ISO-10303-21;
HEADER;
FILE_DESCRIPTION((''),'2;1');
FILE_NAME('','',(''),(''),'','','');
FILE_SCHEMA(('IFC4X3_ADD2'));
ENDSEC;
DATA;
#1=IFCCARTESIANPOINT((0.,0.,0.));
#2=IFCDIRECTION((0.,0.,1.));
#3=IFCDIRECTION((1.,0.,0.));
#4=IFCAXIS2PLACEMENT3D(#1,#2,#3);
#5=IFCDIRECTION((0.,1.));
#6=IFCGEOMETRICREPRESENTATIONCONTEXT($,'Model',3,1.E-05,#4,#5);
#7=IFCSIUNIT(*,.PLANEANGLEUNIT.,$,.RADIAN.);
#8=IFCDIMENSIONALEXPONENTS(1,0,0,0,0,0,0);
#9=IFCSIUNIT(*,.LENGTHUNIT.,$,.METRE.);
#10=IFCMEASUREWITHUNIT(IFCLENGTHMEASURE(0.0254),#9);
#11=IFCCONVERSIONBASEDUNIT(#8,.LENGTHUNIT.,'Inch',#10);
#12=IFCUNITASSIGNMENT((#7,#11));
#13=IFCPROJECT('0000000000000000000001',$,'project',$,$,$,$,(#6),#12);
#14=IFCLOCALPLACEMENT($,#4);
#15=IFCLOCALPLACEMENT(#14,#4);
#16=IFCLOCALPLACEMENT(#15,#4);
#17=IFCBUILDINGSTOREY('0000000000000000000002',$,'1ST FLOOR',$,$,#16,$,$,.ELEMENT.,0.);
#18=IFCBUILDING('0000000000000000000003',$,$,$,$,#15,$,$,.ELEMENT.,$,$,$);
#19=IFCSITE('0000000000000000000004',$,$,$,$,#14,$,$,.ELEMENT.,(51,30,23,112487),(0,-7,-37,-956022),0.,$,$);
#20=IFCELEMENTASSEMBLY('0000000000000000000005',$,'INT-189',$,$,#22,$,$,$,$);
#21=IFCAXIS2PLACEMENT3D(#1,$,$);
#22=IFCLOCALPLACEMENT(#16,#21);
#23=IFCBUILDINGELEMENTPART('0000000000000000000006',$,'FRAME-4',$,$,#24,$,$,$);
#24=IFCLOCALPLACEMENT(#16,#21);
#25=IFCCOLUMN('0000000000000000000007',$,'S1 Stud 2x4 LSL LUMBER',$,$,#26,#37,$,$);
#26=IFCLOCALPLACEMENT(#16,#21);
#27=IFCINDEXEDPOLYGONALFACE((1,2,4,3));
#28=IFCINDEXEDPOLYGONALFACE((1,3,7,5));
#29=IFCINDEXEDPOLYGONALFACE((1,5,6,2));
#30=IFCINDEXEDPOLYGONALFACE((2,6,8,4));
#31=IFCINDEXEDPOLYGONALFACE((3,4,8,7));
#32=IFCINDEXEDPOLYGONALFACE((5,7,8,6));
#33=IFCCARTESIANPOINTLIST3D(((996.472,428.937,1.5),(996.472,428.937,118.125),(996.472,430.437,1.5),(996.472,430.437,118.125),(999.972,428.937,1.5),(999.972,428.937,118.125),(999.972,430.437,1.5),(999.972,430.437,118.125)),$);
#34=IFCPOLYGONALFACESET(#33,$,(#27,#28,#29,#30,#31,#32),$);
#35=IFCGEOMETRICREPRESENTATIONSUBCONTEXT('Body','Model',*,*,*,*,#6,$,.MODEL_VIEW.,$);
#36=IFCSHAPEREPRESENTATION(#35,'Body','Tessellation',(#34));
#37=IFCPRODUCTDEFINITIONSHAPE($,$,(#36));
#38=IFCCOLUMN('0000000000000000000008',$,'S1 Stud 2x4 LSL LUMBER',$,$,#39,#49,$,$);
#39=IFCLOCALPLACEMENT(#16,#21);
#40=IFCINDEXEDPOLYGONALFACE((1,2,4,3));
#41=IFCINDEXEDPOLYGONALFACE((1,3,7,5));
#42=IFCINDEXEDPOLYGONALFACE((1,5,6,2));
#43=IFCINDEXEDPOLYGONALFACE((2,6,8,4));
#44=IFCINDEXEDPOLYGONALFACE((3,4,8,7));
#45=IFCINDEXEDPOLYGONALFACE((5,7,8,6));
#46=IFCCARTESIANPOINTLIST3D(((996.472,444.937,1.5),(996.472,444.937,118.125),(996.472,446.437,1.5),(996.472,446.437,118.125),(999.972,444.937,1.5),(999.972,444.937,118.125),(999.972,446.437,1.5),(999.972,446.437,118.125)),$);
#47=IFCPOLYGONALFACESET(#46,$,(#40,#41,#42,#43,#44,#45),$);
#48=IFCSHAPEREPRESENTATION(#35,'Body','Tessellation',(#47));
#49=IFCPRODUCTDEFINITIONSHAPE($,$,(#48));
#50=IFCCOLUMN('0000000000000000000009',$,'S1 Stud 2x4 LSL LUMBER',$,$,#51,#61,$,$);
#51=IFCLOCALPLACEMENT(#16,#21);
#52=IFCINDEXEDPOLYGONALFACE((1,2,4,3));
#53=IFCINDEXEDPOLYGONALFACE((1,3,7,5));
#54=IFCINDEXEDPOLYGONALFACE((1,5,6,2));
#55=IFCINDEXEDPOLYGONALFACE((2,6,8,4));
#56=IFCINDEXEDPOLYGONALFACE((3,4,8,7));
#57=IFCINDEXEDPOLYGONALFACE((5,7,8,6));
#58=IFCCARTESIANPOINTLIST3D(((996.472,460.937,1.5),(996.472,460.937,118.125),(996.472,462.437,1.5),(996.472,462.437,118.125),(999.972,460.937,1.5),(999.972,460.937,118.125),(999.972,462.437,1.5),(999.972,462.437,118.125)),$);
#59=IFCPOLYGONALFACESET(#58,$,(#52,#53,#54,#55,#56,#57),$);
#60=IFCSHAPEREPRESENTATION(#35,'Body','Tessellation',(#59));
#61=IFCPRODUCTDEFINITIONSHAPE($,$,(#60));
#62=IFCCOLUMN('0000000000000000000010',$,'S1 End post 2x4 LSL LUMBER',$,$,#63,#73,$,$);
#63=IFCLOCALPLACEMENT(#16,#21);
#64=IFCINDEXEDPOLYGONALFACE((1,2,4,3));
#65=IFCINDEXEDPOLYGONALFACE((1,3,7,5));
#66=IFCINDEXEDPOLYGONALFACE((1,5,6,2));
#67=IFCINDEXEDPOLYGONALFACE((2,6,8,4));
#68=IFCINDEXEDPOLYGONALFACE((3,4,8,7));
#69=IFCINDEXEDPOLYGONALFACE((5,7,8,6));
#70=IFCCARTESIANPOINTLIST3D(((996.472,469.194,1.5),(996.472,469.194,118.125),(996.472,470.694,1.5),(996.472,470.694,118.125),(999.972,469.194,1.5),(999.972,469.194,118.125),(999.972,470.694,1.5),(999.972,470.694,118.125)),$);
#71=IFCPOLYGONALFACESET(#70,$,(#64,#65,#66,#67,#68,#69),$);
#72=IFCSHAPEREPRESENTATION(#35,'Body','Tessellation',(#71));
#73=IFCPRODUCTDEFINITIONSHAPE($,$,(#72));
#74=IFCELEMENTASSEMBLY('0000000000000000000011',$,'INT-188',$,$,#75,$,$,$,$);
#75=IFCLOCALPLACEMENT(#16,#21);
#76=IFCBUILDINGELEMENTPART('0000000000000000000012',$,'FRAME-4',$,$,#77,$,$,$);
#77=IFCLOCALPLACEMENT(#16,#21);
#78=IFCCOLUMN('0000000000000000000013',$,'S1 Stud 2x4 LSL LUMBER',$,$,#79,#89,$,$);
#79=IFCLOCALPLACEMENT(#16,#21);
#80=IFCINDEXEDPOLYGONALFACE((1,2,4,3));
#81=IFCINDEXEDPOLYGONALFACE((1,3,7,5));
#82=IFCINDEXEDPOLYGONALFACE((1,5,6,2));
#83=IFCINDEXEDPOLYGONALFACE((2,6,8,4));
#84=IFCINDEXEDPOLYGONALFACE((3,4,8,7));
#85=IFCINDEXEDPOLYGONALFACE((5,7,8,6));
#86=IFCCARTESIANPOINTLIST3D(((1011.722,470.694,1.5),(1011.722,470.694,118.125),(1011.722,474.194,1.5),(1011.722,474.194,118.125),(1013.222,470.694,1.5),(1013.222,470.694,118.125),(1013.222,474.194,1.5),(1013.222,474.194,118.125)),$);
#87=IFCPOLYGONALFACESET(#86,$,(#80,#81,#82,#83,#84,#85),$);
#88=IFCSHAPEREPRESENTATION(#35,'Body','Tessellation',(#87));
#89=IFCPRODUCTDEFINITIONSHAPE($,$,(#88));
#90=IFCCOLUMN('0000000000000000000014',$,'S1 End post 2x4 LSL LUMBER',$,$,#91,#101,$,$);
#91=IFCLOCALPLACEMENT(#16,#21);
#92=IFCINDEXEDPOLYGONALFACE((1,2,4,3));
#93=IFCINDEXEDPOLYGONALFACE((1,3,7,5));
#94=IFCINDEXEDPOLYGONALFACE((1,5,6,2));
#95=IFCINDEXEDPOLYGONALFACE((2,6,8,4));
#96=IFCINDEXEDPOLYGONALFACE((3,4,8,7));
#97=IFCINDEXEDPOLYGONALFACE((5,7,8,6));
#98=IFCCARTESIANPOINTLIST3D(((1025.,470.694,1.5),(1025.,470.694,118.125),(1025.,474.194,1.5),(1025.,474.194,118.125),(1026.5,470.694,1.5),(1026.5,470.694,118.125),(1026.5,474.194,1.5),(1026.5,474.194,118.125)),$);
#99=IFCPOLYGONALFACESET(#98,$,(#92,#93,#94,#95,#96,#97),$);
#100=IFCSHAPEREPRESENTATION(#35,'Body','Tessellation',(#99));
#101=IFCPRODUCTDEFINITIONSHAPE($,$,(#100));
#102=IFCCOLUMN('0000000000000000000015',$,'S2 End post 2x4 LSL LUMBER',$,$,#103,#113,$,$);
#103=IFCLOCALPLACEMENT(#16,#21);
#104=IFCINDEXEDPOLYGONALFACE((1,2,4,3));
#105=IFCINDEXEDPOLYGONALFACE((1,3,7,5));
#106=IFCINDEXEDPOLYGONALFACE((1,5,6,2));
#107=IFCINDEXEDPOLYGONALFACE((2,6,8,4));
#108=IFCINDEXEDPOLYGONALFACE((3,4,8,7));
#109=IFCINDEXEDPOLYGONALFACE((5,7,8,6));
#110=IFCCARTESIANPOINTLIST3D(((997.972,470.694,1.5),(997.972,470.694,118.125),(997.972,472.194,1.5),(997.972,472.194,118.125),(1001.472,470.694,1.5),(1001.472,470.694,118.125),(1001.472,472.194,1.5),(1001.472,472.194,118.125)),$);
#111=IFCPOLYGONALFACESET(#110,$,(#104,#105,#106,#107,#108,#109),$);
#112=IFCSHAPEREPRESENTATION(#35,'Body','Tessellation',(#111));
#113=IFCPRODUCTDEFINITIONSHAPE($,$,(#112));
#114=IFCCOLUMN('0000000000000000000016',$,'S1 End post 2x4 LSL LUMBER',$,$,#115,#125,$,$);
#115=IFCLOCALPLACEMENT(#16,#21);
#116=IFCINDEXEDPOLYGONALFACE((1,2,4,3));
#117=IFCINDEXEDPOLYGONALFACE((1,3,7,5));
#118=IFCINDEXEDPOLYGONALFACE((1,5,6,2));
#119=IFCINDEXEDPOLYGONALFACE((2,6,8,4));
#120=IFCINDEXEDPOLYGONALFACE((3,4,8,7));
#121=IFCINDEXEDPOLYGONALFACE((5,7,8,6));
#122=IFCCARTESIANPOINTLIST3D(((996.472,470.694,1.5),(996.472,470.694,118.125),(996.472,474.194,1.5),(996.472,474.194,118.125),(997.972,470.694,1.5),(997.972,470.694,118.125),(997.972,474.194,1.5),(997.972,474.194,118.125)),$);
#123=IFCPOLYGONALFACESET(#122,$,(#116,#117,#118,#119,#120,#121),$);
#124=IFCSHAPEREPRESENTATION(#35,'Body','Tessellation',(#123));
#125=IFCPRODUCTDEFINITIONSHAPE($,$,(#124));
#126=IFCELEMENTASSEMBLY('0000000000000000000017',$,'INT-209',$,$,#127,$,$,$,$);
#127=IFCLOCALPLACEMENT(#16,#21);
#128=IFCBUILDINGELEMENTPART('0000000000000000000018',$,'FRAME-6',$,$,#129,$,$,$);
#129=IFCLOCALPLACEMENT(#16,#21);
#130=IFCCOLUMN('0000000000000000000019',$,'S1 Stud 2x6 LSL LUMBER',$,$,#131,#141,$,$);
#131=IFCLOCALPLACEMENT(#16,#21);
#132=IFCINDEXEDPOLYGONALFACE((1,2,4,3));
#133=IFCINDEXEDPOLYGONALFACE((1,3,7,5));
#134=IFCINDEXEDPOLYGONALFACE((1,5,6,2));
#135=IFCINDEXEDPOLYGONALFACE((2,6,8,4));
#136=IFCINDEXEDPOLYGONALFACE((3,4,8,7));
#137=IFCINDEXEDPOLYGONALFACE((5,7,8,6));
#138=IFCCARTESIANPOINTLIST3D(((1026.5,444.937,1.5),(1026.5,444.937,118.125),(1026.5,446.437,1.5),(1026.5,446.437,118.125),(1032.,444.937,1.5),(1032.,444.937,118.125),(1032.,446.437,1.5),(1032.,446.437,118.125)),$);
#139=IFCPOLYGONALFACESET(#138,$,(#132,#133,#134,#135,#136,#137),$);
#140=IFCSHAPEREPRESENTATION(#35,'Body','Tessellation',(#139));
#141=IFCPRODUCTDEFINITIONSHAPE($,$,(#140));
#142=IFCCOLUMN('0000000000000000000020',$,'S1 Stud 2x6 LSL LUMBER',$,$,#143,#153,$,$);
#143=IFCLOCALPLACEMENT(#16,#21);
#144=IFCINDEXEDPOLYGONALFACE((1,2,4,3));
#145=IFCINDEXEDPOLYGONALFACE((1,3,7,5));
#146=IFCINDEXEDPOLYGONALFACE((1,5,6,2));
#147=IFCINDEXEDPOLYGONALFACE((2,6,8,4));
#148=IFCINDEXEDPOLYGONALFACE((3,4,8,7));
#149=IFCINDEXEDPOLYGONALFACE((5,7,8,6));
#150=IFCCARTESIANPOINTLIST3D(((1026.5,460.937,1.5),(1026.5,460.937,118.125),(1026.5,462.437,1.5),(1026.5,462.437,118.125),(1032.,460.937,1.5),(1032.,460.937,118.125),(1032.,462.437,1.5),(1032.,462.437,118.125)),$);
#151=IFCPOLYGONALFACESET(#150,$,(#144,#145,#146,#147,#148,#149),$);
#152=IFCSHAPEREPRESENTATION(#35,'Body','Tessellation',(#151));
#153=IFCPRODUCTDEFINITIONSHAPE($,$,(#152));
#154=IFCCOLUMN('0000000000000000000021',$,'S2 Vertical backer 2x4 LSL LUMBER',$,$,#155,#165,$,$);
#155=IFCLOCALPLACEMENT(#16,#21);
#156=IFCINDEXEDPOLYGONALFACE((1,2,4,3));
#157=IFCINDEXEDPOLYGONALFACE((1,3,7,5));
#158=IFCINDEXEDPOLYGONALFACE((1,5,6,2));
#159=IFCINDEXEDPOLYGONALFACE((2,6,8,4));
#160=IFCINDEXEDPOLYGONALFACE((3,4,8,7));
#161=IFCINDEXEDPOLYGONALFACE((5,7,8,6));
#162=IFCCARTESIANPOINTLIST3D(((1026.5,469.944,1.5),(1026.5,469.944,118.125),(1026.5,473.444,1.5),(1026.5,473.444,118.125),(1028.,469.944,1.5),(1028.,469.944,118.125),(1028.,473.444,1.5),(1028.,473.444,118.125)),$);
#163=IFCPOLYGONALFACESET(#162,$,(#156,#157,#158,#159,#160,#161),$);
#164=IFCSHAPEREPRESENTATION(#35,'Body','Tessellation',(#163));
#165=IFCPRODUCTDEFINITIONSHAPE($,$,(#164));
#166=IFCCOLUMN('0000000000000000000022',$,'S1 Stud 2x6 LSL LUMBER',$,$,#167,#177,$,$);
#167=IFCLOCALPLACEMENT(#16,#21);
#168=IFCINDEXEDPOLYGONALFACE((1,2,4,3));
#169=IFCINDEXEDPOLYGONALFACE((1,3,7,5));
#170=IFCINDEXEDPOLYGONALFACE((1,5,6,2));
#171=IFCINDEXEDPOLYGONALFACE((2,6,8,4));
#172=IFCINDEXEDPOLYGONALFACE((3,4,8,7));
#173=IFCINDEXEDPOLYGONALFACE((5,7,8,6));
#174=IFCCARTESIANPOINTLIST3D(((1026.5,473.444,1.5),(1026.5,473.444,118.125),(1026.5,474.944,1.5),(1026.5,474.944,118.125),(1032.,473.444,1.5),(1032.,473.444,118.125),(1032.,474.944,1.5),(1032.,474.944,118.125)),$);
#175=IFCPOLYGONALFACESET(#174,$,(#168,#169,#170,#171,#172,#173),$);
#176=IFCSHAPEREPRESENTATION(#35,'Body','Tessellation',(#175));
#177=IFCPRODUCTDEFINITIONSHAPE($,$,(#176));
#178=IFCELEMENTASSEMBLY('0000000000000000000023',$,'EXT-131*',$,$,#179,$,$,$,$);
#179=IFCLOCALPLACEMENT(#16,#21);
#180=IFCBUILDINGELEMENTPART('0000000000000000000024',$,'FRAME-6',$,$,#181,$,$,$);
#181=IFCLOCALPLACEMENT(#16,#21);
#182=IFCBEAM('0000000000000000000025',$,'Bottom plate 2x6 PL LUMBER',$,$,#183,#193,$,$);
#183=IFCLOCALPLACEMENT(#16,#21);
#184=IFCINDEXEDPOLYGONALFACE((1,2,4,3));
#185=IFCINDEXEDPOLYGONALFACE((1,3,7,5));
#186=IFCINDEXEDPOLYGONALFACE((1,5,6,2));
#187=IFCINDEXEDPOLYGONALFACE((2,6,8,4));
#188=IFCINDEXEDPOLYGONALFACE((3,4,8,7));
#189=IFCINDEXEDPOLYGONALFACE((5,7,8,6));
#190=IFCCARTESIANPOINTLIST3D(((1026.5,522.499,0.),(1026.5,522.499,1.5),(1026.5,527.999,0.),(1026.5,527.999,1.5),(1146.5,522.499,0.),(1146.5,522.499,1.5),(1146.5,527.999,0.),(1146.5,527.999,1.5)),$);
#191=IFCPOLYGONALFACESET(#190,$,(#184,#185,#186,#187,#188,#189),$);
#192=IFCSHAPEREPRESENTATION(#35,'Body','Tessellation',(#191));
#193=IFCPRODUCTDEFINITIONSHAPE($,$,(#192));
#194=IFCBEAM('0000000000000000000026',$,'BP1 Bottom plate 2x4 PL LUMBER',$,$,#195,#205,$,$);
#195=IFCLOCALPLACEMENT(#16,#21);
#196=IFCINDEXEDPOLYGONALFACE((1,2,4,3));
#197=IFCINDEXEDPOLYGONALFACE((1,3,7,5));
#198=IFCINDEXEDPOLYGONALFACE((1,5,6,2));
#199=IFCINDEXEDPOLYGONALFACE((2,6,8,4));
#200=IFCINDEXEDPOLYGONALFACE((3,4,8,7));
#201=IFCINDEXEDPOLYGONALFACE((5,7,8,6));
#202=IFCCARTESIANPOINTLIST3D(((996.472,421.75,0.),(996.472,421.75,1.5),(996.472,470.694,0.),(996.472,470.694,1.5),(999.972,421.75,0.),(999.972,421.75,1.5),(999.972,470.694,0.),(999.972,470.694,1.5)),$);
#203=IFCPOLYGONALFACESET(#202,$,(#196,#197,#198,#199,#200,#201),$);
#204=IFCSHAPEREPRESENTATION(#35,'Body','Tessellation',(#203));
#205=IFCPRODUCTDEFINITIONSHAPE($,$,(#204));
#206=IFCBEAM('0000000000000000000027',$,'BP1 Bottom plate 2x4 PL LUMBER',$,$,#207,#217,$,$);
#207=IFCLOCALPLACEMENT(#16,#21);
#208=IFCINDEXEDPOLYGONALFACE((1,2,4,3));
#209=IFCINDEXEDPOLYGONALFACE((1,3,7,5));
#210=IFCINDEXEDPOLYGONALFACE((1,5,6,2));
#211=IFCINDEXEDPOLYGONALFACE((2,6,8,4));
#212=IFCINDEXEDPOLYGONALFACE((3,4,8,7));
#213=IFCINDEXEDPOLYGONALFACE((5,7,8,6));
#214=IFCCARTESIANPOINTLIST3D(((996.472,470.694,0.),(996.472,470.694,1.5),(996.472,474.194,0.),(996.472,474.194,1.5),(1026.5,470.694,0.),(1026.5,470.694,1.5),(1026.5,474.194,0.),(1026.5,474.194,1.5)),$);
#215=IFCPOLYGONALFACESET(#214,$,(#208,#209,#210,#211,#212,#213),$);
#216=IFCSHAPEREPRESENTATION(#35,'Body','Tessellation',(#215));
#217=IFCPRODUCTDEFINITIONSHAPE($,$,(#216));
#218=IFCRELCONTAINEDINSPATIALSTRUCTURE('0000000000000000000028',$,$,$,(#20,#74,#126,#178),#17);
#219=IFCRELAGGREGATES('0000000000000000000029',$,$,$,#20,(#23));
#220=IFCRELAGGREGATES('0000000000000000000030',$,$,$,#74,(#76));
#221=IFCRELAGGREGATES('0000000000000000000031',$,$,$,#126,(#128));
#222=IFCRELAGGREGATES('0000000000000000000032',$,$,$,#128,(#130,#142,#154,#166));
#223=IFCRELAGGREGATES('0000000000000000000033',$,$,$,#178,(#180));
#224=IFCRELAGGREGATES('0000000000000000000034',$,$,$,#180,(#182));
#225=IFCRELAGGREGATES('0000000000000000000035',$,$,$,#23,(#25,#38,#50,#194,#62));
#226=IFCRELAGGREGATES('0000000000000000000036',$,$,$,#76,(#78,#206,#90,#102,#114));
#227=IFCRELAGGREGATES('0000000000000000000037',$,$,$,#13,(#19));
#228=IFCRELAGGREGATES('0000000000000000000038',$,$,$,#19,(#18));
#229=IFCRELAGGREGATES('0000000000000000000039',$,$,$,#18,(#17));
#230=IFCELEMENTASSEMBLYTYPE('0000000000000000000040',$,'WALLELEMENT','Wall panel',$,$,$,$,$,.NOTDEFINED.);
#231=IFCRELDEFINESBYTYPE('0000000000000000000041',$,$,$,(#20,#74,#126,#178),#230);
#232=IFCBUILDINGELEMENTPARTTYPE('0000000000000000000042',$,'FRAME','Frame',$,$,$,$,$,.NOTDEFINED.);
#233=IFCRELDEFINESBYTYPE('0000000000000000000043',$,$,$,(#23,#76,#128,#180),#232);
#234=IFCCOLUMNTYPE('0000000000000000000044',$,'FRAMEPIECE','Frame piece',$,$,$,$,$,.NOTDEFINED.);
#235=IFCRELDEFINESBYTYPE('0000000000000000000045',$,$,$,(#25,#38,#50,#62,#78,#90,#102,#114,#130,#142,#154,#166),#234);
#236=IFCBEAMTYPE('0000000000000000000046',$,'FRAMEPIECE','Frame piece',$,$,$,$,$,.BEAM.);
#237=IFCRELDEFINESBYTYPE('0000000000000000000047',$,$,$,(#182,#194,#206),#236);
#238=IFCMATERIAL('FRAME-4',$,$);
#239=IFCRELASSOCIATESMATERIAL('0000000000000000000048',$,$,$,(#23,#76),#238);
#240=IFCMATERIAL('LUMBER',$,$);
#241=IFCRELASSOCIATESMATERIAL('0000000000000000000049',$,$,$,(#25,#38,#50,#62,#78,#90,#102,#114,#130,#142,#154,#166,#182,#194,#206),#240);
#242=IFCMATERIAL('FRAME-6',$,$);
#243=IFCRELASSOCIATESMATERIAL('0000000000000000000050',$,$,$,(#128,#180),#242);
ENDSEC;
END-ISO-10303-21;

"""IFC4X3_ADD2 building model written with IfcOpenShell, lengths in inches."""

from ifc_helpers import new_model, entity, si_unit, converted_unit, direction, frame, origin_with_axes, origin_2d_with_axis, place, context, subcontext, project, spatial, rectangle, extrude, material, type_object, element, aggregate, save


model = new_model("IFC4X3_ADD2")

# Units and contexts
model_context = context("Model", 3, precision=1e-05, world=origin_with_axes(), true_north=direction((0.0, 1.0)))
body_context = subcontext(model_context, "Body", "Model", "MODEL_VIEW")
ifc_project = project(units=[si_unit("PLANEANGLEUNIT", "RADIAN"), converted_unit("LENGTHUNIT", "Inch", entity("IfcLengthMeasure", 0.0254), si_unit("LENGTHUNIT", "METRE"), dimensions=[1, 0, 0, 0, 0, 0, 0])], contexts=[model_context])

# Site, building, storey
site_placement = place(None, origin_with_axes())
site = spatial("IfcSite", under=ifc_project, at=site_placement, CompositionType="ELEMENT", RefLatitude=(51, 30, 23, 112487), RefLongitude=(0, -7, -37, -956022), RefElevation=0.0)
building_placement = place(site_placement, origin_with_axes())
building = spatial("IfcBuilding", under=site, at=building_placement, CompositionType="ELEMENT")
storey_placement = place(building_placement, origin_with_axes())
storey = spatial("IfcBuildingStorey", under=building, at=storey_placement, Name="1ST FLOOR", CompositionType="ELEMENT", Elevation=0.0)

# Element assemblies, building element parts, columns
element_assembly_type_1 = type_object("IfcElementAssemblyType", Name="WALLELEMENT", Description="Wall panel", PredefinedType="NOTDEFINED")
assembly_1_placement = place(storey_placement, origin_with_axes())
assembly_1 = element("IfcElementAssembly", 1, at=assembly_1_placement, inside=storey, type_object=element_assembly_type_1, Name="INT-189")
ifc_material_1 = material(Name="FRAME-4")
building_element_part_type = type_object("IfcBuildingElementPartType", Name="FRAME", Description="Frame", PredefinedType="NOTDEFINED")
building_element_part_1_placement = place(storey_placement, origin_with_axes())
building_element_part_1 = element("IfcBuildingElementPart", 2, at=building_element_part_1_placement, type_object=building_element_part_type, material=ifc_material_1, Name="FRAME-4")
aggregate(assembly_1, [building_element_part_1])
ifc_material_2 = material(Name="LUMBER")
column_type = type_object("IfcColumnType", Name="FRAMEPIECE", Description="Frame piece", PredefinedType="NOTDEFINED")
column_1_placement = place(storey_placement, frame((998.222, 429.687, 118.125), z_axis=(0.0, 0.0, -1.0), x_axis=(0.0, -1.0, 0.0)))
column_1 = element("IfcColumn", 3, at=column_1_placement, type_object=column_type, material=ifc_material_2, Name="S1 Stud 2x4 LSL LUMBER", context=body_context, shape_type="SweptSolid", body=[
    extrude(rectangle(XDim=1.5, YDim=3.5, at=origin_2d_with_axis()), origin_with_axes(), (0.0, 0.0, 1.0), 116.625),
])
column_2_placement = place(storey_placement, frame((998.222, 445.687, 118.125), z_axis=(0.0, 0.0, -1.0), x_axis=(0.0, -1.0, 0.0)))
column_2 = element("IfcColumn", 4, at=column_2_placement, type_object=column_type, material=ifc_material_2, Name="S1 Stud 2x4 LSL LUMBER", context=body_context, shape_type="SweptSolid", body=[
    extrude(rectangle(XDim=1.5, YDim=3.5, at=origin_2d_with_axis()), origin_with_axes(), (0.0, 0.0, 1.0), 116.625),
])
column_3_placement = place(storey_placement, frame((998.222, 461.687, 118.125), z_axis=(0.0, 0.0, -1.0), x_axis=(0.0, -1.0, 0.0)))
column_3 = element("IfcColumn", 5, at=column_3_placement, type_object=column_type, material=ifc_material_2, Name="S1 Stud 2x4 LSL LUMBER", context=body_context, shape_type="SweptSolid", body=[
    extrude(rectangle(XDim=1.5, YDim=3.5, at=origin_2d_with_axis()), origin_with_axes(), (0.0, 0.0, 1.0), 116.625),
])
column_4_placement = place(storey_placement, frame((998.222, 469.944, 118.125), z_axis=(0.0, 0.0, -1.0), x_axis=(0.0, -1.0, 0.0)))
column_4 = element("IfcColumn", 6, at=column_4_placement, type_object=column_type, material=ifc_material_2, Name="S1 End post 2x4 LSL LUMBER", context=body_context, shape_type="SweptSolid", body=[
    extrude(rectangle(XDim=1.5, YDim=3.5, at=origin_2d_with_axis()), origin_with_axes(), (0.0, 0.0, 1.0), 116.625),
])
assembly_2_placement = place(storey_placement, origin_with_axes())
assembly_2 = element("IfcElementAssembly", 7, at=assembly_2_placement, inside=storey, type_object=element_assembly_type_1, Name="INT-188")
building_element_part_2_placement = place(storey_placement, origin_with_axes())
building_element_part_2 = element("IfcBuildingElementPart", 8, at=building_element_part_2_placement, type_object=building_element_part_type, material=ifc_material_1, Name="FRAME-4")
aggregate(assembly_2, [building_element_part_2])
column_5_placement = place(storey_placement, frame((1012.472, 472.444, 118.125), z_axis=(0.0, 0.0, -1.0), x_axis=(1.0, 0.0, 0.0)))
column_5 = element("IfcColumn", 9, at=column_5_placement, type_object=column_type, material=ifc_material_2, Name="S1 Stud 2x4 LSL LUMBER", context=body_context, shape_type="SweptSolid", body=[
    extrude(rectangle(XDim=1.5, YDim=3.5, at=origin_2d_with_axis()), origin_with_axes(), (0.0, 0.0, 1.0), 116.625),
])
column_6_placement = place(storey_placement, frame((1025.75, 472.444, 1.5), z_axis=(0.0, 0.0, 1.0), x_axis=(-1.0, 0.0, 0.0)))
column_6 = element("IfcColumn", 10, at=column_6_placement, type_object=column_type, material=ifc_material_2, Name="S1 End post 2x4 LSL LUMBER", context=body_context, shape_type="SweptSolid", body=[
    extrude(rectangle(XDim=1.5, YDim=3.5, at=origin_2d_with_axis()), origin_with_axes(), (0.0, 0.0, 1.0), 116.625),
])
column_7_placement = place(storey_placement, frame((999.722, 471.444, 118.125), z_axis=(0.0, 0.0, -1.0), x_axis=(0.0, 1.0, 0.0)))
column_7 = element("IfcColumn", 11, at=column_7_placement, type_object=column_type, material=ifc_material_2, Name="S2 End post 2x4 LSL LUMBER", context=body_context, shape_type="SweptSolid", body=[
    extrude(rectangle(XDim=1.5, YDim=3.5, at=origin_2d_with_axis()), origin_with_axes(), (0.0, 0.0, 1.0), 116.625),
])
column_8_placement = place(storey_placement, frame((997.222, 472.444, 118.125), z_axis=(0.0, 0.0, -1.0), x_axis=(1.0, 0.0, 0.0)))
column_8 = element("IfcColumn", 12, at=column_8_placement, type_object=column_type, material=ifc_material_2, Name="S1 End post 2x4 LSL LUMBER", context=body_context, shape_type="SweptSolid", body=[
    extrude(rectangle(XDim=1.5, YDim=3.5, at=origin_2d_with_axis()), origin_with_axes(), (0.0, 0.0, 1.0), 116.625),
])
assembly_3_placement = place(storey_placement, origin_with_axes())
assembly_3 = element("IfcElementAssembly", 13, at=assembly_3_placement, inside=storey, type_object=element_assembly_type_1, Name="INT-209")
ifc_material_3 = material(Name="FRAME-6")
building_element_part_3_placement = place(storey_placement, origin_with_axes())
building_element_part_3 = element("IfcBuildingElementPart", 14, at=building_element_part_3_placement, type_object=building_element_part_type, material=ifc_material_3, Name="FRAME-6")
aggregate(assembly_3, [building_element_part_3])
column_9_placement = place(storey_placement, frame((1029.25, 445.687, 118.125), z_axis=(0.0, 0.0, -1.0), x_axis=(0.0, -1.0, 0.0)))
column_9 = element("IfcColumn", 15, at=column_9_placement, type_object=column_type, material=ifc_material_2, Name="S1 Stud 2x6 LSL LUMBER", context=body_context, shape_type="SweptSolid", body=[
    extrude(rectangle(XDim=1.5, YDim=5.5, at=origin_2d_with_axis()), origin_with_axes(), (0.0, 0.0, 1.0), 116.625),
])
column_10_placement = place(storey_placement, frame((1029.25, 461.687, 118.125), z_axis=(0.0, 0.0, -1.0), x_axis=(0.0, -1.0, 0.0)))
column_10 = element("IfcColumn", 16, at=column_10_placement, type_object=column_type, material=ifc_material_2, Name="S1 Stud 2x6 LSL LUMBER", context=body_context, shape_type="SweptSolid", body=[
    extrude(rectangle(XDim=1.5, YDim=5.5, at=origin_2d_with_axis()), origin_with_axes(), (0.0, 0.0, 1.0), 116.625),
])
column_11_placement = place(storey_placement, frame((1027.25, 471.694, 1.5), z_axis=(0.0, 0.0, 1.0), x_axis=(1.0, 0.0, 0.0)))
column_11 = element("IfcColumn", 17, at=column_11_placement, type_object=column_type, material=ifc_material_2, Name="S2 Vertical backer 2x4 LSL LUMBER", context=body_context, shape_type="SweptSolid", body=[
    extrude(rectangle(XDim=1.5, YDim=3.5, at=origin_2d_with_axis()), origin_with_axes(), (0.0, 0.0, 1.0), 116.625),
])
column_12_placement = place(storey_placement, frame((1029.25, 474.194, 118.125), z_axis=(0.0, 0.0, -1.0), x_axis=(0.0, -1.0, 0.0)))
column_12 = element("IfcColumn", 18, at=column_12_placement, type_object=column_type, material=ifc_material_2, Name="S1 Stud 2x6 LSL LUMBER", context=body_context, shape_type="SweptSolid", body=[
    extrude(rectangle(XDim=1.5, YDim=5.5, at=origin_2d_with_axis()), origin_with_axes(), (0.0, 0.0, 1.0), 116.625),
])
aggregate(building_element_part_3, [column_9, column_10, column_11, column_12])

# Element assembly, building element part, beam
assembly_4_placement = place(storey_placement, origin_with_axes())
assembly_4 = element("IfcElementAssembly", 19, at=assembly_4_placement, inside=storey, type_object=element_assembly_type_1, Name="EXT-131*")
building_element_part_4_placement = place(storey_placement, origin_with_axes())
building_element_part_4 = element("IfcBuildingElementPart", 20, at=building_element_part_4_placement, type_object=building_element_part_type, material=ifc_material_3, Name="FRAME-6")
aggregate(assembly_4, [building_element_part_4])
beam_type_1 = type_object("IfcBeamType", Name="FRAMEPIECE", Description="Frame piece", PredefinedType="BEAM")
beam_1_placement = place(storey_placement, frame((1026.5, 525.249, 0.75), z_axis=(1.0, 0.0, 0.0), x_axis=(0.0, 0.0, 1.0)))
beam_1 = element("IfcBeam", 21, at=beam_1_placement, type_object=beam_type_1, material=ifc_material_2, Name="Bottom plate 2x6 PL LUMBER", context=body_context, shape_type="SweptSolid", body=[
    extrude(rectangle(XDim=1.5, YDim=5.5, at=origin_2d_with_axis()), origin_with_axes(), (0.0, 0.0, 1.0), 120.0),
])
aggregate(building_element_part_4, [beam_1])

# Beams
beam_2_placement = place(storey_placement, frame((998.222, 470.694, 0.75), z_axis=(0.0, -1.0, 0.0), x_axis=(0.0, 0.0, 1.0)))
beam_2 = element("IfcBeam", 22, at=beam_2_placement, type_object=beam_type_1, material=ifc_material_2, Name="BP1 Bottom plate 2x4 PL LUMBER", context=body_context, shape_type="SweptSolid", body=[
    extrude(rectangle(XDim=1.5, YDim=3.5, at=origin_2d_with_axis()), origin_with_axes(), (0.0, 0.0, 1.0), 48.944),
])
aggregate(building_element_part_1, [column_1, column_2, column_3, beam_2, column_4])
beam_3_placement = place(storey_placement, frame((996.472, 472.444, 0.75), z_axis=(1.0, 0.0, 0.0), x_axis=(0.0, 0.0, 1.0)))
beam_3 = element("IfcBeam", 23, at=beam_3_placement, type_object=beam_type_1, material=ifc_material_2, Name="BP1 Bottom plate 2x4 PL LUMBER", context=body_context, shape_type="SweptSolid", body=[
    extrude(rectangle(XDim=1.5, YDim=3.5, at=origin_2d_with_axis()), origin_with_axes(), (0.0, 0.0, 1.0), 30.028),
])
aggregate(building_element_part_2, [column_5, beam_3, column_6, column_7, column_8])

save(model, "model.ifc")
